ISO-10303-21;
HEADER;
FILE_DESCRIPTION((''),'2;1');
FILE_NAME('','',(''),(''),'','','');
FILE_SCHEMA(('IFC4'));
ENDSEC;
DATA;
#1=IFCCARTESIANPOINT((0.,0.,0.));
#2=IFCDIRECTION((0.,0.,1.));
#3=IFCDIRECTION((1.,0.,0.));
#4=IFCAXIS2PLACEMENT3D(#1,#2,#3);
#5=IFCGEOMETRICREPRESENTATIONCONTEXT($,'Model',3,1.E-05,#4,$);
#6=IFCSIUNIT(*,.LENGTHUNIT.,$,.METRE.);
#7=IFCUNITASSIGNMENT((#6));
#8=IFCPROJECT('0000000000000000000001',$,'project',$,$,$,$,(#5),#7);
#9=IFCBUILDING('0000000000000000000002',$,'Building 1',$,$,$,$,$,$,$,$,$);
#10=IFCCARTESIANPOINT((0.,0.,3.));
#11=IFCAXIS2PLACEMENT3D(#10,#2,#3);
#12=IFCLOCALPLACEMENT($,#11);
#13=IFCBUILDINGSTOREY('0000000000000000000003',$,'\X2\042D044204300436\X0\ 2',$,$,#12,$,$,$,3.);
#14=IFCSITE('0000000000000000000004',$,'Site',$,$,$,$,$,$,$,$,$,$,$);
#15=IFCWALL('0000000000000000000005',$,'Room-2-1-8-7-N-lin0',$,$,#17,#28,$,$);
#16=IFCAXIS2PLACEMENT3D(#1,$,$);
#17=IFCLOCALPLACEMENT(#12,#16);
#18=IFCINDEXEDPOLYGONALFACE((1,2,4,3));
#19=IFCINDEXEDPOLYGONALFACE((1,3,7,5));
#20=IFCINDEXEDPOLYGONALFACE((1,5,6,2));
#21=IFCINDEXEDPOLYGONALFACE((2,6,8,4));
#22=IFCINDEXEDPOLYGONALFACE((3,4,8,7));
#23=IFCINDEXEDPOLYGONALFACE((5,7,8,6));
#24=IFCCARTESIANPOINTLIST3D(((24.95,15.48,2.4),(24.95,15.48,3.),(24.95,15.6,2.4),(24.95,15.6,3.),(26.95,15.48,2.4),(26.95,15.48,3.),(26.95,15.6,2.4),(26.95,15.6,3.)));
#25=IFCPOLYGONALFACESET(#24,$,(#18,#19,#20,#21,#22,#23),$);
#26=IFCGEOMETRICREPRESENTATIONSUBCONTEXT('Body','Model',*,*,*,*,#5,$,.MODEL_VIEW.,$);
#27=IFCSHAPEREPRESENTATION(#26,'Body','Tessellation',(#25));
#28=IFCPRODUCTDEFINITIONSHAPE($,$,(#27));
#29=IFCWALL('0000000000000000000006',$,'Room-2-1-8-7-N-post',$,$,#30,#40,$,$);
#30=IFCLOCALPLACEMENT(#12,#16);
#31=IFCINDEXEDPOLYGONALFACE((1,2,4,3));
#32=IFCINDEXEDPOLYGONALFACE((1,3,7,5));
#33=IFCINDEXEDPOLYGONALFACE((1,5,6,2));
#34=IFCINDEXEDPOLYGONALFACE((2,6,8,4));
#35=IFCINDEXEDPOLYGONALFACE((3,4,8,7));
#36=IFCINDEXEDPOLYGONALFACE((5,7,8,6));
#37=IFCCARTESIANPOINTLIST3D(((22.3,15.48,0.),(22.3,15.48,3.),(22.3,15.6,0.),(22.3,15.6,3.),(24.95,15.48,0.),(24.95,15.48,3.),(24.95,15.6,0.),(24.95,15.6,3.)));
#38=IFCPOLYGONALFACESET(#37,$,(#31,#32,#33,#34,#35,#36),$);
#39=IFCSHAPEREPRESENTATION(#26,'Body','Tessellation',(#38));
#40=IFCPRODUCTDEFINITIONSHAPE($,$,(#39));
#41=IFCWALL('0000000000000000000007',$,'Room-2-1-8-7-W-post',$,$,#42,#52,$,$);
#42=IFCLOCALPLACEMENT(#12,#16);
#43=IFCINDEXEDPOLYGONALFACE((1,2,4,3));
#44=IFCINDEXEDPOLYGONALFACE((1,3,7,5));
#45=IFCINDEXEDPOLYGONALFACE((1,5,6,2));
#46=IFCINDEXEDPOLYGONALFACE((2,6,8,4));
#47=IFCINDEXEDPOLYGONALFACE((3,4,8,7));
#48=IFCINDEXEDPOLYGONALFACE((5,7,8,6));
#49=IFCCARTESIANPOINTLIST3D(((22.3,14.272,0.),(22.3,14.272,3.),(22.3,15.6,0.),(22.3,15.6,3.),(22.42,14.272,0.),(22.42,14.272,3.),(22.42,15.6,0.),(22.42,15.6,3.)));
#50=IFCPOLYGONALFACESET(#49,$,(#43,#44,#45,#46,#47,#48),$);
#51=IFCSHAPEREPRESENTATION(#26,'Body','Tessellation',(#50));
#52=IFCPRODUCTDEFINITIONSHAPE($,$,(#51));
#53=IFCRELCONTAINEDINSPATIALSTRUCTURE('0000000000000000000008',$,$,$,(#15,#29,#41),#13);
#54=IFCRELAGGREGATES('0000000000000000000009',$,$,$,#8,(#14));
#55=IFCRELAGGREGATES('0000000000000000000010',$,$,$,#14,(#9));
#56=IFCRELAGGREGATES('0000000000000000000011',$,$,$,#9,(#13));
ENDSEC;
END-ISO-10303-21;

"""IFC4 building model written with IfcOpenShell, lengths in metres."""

from ifc_helpers import new_model, si_unit, frame, origin_with_axes, place, context, subcontext, project, spatial, indexed_curve, outline, extrude, element, save


model = new_model("IFC4")

# Units and contexts
model_context = context("Model", 3, precision=1e-05, world=origin_with_axes())
body_context = subcontext(model_context, "Body", "Model", "MODEL_VIEW")
ifc_project = project(units=[si_unit("LENGTHUNIT", "METRE")], contexts=[model_context])

# Site, building, storey
site = spatial("IfcSite", under=ifc_project, Name="Site")
building = spatial("IfcBuilding", under=site, Name="Building 1")
storey_placement = place(None, frame((0.0, 0.0, 3.0), z_axis=(0.0, 0.0, 1.0), x_axis=(1.0, 0.0, 0.0)))
storey = spatial("IfcBuildingStorey", under=building, at=storey_placement, Name="Этаж 2", Elevation=3.0)

# Walls
wall_1_placement = place(storey_placement, frame((26.95, 15.6, 2.4), z_axis=(0.0, 0.0, 1.0), x_axis=(-1.0, 0.0, 0.0)))
element("IfcWall", 1, at=wall_1_placement, inside=storey, Name="Room-2-1-8-7-N-lin0", context=body_context, shape_type="SweptSolid", body=[
    extrude(outline(indexed_curve([(0.0, 0.0), (0.0, 0.12), (2.0, 0.12), (2.0, 0.0), (0.0, 0.0)], self_intersect=False)), origin_with_axes(), (0.0, 0.0, 1.0), 0.6),
])
wall_2_placement = place(storey_placement, frame((24.95, 15.6, 0.0), z_axis=(0.0, 0.0, 1.0), x_axis=(-1.0, 0.0, 0.0)))
element("IfcWall", 2, at=wall_2_placement, inside=storey, Name="Room-2-1-8-7-N-post", context=body_context, shape_type="SweptSolid", body=[
    extrude(outline(indexed_curve([(0.0, 0.0), (0.0, 0.12), (2.65, 0.12), (2.65, 0.0), (0.0, 0.0)], self_intersect=False)), origin_with_axes(), (0.0, 0.0, 1.0), 3.0),
])
wall_3_placement = place(storey_placement, frame((22.3, 15.6, 0.0), z_axis=(0.0, 0.0, 1.0), x_axis=(0.0, -1.0, 0.0)))
element("IfcWall", 3, at=wall_3_placement, inside=storey, Name="Room-2-1-8-7-W-post", context=body_context, shape_type="SweptSolid", body=[
    extrude(outline(indexed_curve([(0.0, 0.0), (0.0, 0.12), (1.328, 0.12), (1.328, 0.0), (0.0, 0.0)], self_intersect=False)), origin_with_axes(), (0.0, 0.0, 1.0), 3.0),
])

save(model, "model.ifc")
